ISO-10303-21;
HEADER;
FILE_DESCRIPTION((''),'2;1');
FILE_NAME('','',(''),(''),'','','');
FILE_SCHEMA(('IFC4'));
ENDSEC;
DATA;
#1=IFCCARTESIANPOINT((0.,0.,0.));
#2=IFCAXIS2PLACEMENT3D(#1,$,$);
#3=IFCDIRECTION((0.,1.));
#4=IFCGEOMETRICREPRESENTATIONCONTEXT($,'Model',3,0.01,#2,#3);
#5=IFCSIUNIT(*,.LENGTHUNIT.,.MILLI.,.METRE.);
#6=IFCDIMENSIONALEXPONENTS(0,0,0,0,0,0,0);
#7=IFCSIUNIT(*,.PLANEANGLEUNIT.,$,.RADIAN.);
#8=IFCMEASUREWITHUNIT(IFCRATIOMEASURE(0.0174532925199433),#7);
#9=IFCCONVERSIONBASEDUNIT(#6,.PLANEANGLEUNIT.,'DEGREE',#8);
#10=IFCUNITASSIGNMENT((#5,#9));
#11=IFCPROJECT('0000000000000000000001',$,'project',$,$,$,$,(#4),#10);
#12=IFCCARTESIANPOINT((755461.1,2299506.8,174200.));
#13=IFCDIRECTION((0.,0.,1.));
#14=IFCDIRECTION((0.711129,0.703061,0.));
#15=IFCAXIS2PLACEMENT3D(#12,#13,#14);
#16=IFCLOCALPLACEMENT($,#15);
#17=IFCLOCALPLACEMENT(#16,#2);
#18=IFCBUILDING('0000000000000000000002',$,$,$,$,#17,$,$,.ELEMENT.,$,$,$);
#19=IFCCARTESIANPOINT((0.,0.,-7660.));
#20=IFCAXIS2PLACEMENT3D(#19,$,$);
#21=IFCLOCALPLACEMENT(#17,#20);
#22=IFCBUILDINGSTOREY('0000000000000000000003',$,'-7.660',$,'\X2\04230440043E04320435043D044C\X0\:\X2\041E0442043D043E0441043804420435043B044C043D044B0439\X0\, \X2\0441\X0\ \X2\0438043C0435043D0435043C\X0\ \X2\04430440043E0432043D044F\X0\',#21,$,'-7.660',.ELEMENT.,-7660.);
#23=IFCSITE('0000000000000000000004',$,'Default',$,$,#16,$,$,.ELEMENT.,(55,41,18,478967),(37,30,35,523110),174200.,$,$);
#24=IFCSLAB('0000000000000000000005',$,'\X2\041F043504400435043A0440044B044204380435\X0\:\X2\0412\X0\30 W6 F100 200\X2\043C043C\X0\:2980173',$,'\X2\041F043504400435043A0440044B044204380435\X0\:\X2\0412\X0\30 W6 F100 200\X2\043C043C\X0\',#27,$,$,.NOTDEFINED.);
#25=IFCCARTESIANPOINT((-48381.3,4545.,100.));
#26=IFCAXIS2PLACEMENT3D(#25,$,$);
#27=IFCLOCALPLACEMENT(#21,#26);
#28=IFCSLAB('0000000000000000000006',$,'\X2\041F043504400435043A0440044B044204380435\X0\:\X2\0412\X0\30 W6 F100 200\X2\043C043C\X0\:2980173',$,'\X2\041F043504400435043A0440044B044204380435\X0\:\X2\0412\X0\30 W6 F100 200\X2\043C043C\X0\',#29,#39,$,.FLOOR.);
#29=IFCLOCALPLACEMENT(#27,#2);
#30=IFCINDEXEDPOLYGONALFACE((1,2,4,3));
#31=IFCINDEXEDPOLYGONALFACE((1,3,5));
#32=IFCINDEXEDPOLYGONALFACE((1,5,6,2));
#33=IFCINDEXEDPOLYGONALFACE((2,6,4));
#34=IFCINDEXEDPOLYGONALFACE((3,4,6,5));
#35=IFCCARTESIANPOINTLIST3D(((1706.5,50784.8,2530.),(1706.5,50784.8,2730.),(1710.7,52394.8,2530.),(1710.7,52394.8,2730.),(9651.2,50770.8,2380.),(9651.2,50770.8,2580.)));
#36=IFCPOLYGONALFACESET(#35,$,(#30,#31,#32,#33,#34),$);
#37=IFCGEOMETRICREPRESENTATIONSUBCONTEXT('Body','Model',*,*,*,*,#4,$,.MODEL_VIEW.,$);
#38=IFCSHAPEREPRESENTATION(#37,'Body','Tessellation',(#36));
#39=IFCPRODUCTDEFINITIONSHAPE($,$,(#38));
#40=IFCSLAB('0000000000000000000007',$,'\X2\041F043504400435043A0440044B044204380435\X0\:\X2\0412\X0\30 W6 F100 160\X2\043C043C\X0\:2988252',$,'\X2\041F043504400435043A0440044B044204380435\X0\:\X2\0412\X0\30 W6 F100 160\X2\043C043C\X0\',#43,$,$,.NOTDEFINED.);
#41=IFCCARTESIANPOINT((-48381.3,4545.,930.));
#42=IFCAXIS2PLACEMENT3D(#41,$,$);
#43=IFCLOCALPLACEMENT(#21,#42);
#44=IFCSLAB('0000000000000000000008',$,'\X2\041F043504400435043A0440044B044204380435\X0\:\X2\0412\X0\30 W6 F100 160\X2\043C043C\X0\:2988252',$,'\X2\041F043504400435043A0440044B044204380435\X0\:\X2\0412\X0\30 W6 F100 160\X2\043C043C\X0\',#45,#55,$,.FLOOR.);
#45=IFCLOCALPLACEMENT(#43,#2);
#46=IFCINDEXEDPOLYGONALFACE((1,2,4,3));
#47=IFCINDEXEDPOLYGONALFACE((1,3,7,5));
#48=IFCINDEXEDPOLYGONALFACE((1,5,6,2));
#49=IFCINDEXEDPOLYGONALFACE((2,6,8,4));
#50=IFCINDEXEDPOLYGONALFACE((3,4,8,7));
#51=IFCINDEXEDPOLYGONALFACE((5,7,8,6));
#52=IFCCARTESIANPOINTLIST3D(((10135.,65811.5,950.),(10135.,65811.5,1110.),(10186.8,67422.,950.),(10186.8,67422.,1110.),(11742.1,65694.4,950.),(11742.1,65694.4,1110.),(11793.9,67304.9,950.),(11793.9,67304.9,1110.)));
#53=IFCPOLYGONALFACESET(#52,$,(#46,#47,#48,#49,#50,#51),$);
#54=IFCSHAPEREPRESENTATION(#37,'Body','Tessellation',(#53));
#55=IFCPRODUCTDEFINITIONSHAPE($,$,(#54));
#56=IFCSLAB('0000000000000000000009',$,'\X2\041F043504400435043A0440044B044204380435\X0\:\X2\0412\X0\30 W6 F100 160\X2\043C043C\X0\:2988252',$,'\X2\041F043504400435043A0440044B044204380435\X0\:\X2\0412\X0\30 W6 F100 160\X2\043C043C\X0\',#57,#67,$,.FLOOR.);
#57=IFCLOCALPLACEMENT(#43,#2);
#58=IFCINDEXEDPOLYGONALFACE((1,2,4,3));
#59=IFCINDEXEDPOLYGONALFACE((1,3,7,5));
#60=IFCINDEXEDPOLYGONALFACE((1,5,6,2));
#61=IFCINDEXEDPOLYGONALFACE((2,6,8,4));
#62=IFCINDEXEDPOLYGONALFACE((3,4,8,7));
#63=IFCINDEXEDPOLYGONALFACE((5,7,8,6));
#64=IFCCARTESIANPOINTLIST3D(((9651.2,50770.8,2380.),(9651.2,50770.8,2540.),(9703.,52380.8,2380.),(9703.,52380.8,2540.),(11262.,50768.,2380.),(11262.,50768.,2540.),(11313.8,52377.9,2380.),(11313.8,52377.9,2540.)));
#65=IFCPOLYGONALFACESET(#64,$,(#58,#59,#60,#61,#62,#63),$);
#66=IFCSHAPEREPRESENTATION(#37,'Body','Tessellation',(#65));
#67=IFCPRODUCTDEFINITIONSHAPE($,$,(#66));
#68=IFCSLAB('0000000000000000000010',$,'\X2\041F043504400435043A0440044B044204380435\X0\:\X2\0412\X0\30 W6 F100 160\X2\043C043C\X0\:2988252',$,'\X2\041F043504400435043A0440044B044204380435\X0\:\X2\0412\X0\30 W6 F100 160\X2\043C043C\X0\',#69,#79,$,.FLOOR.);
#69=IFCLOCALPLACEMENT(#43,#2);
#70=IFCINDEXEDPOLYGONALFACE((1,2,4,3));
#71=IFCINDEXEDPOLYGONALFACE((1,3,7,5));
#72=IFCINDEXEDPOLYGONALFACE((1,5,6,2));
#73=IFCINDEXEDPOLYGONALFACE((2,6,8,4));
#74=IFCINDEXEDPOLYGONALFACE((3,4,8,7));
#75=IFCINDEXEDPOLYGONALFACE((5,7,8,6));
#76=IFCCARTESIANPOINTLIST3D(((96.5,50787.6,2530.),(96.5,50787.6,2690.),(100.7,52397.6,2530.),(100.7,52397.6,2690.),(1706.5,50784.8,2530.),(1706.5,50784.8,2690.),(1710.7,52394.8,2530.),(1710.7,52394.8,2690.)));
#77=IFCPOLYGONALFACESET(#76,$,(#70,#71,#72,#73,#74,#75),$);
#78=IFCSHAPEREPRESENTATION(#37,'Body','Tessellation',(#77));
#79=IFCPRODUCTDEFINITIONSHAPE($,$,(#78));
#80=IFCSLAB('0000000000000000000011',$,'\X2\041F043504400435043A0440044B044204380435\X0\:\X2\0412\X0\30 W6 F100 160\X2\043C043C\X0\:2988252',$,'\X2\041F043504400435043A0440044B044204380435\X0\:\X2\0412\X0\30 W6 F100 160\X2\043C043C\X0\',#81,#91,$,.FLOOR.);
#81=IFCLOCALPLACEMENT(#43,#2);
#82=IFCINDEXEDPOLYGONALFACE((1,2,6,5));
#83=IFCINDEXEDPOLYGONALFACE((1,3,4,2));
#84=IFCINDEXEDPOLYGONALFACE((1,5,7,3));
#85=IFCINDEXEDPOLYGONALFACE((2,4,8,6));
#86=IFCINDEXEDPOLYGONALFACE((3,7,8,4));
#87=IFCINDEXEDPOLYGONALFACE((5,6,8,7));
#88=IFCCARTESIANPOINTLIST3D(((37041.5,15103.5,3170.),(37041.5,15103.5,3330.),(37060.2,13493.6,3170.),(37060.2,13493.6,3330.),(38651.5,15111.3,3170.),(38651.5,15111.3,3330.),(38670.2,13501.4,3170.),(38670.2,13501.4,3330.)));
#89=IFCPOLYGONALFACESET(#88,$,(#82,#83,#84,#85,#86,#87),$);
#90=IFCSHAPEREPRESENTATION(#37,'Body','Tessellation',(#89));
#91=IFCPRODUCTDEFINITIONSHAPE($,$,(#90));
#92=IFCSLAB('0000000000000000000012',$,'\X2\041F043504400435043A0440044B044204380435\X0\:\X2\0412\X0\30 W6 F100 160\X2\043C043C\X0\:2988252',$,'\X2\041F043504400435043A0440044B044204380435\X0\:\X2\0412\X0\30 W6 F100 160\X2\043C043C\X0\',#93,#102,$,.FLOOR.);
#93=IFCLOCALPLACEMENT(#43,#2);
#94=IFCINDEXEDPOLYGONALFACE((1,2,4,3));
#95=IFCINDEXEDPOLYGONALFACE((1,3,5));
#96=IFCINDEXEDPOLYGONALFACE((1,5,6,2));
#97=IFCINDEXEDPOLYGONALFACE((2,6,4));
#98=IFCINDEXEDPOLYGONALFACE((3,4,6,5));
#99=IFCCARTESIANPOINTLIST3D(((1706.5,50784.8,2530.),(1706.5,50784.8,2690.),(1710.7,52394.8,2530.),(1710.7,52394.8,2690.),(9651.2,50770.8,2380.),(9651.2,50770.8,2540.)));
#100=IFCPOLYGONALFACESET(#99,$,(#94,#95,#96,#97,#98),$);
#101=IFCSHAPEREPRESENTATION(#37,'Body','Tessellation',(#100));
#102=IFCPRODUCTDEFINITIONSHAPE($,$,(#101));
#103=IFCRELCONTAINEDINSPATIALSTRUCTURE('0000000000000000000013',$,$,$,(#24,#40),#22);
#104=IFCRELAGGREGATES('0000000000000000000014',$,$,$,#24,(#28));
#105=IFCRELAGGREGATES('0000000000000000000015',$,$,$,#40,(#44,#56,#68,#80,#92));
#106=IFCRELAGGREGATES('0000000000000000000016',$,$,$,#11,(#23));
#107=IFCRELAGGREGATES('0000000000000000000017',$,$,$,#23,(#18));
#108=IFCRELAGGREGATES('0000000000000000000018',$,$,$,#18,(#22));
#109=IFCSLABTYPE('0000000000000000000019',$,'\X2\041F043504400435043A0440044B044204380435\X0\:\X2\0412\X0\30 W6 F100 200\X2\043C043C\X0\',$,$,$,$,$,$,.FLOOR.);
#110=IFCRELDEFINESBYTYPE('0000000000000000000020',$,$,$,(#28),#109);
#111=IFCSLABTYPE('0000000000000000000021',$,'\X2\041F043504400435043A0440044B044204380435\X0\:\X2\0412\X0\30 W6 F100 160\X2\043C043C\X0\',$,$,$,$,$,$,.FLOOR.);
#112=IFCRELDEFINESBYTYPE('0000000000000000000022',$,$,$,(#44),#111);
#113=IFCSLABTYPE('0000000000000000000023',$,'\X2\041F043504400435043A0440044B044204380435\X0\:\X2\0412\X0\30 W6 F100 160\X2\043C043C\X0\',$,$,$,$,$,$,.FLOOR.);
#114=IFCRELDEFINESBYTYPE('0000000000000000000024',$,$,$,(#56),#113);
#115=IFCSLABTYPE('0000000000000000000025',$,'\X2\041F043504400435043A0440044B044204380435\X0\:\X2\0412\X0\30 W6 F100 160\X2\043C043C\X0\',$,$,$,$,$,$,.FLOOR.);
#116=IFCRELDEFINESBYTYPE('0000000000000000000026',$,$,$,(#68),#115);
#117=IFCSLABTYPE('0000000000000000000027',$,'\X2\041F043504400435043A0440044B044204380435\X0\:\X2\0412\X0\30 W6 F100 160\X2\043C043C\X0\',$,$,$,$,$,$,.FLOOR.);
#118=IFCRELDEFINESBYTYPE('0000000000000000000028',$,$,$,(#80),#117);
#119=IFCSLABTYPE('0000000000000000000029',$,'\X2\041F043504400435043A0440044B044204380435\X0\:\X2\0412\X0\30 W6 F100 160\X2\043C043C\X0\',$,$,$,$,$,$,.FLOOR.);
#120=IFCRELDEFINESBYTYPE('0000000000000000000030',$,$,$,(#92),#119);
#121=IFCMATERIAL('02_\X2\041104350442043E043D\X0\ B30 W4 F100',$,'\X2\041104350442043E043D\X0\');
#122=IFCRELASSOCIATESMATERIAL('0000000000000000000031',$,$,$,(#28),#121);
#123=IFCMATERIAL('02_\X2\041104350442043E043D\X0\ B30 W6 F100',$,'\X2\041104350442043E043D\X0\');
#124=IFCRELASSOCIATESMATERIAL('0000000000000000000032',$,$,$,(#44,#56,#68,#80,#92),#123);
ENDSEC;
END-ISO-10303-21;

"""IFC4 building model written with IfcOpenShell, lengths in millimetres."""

from ifc_helpers import new_model, entity, si_unit, converted_unit, direction, frame, origin, place, context, subcontext, project, spatial, indexed_curve, outline, extrude, material, type_object, element, aggregate, save


model = new_model("IFC4")

# Units and contexts
model_context = context("Model", 3, precision=0.01, world=origin(), true_north=direction((0.0, 1.0)))
body_context = subcontext(model_context, "Body", "Model", "MODEL_VIEW")
ifc_project = project(units=[si_unit("LENGTHUNIT", "METRE", prefix="MILLI"), converted_unit("PLANEANGLEUNIT", "DEGREE", entity("IfcRatioMeasure", 0.0174532925199433), si_unit("PLANEANGLEUNIT", "RADIAN"), dimensions=[0, 0, 0, 0, 0, 0, 0])], contexts=[model_context])

# Site, building, storey
site_placement = place(None, frame((755461.1, 2299506.8, 174200.0), z_axis=(0.0, 0.0, 1.0), x_axis=(0.711129, 0.703061, 0.0)))
site = spatial("IfcSite", under=ifc_project, at=site_placement, Name="Default", CompositionType="ELEMENT", RefLatitude=(55, 41, 18, 478967), RefLongitude=(37, 30, 35, 523110), RefElevation=174200.0)
building_placement = place(site_placement, origin())
building = spatial("IfcBuilding", under=site, at=building_placement, CompositionType="ELEMENT")
storey_placement = place(building_placement, frame((0.0, 0.0, -7660.0)))
storey = spatial("IfcBuildingStorey", under=building, at=storey_placement, Name="-7.660", ObjectType="Уровень:Относительный, с именем уровня", LongName="-7.660", CompositionType="ELEMENT", Elevation=-7660.0)

# Slabs
slab_1_placement = place(storey_placement, frame((-48381.3, 4545.0, 100.0)))
slab_1 = element("IfcSlab", 1, at=slab_1_placement, inside=storey, Name="Перекрытие:В30 W6 F100 200мм:2980173", ObjectType="Перекрытие:В30 W6 F100 200мм", PredefinedType="NOTDEFINED")
ifc_material_1 = material(Name="02_Бетон B30 W4 F100", Category="Бетон")
slab_type_1 = type_object("IfcSlabType", Name="Перекрытие:В30 W6 F100 200мм", PredefinedType="FLOOR")
slab_2_placement = place(slab_1_placement, origin())
slab_2 = element("IfcSlab", 2, at=slab_2_placement, type_object=slab_type_1, material=ifc_material_1, Name="Перекрытие:В30 W6 F100 200мм:2980173", ObjectType="Перекрытие:В30 W6 F100 200мм", PredefinedType="FLOOR", context=body_context, shape_type="SweptSolid", body=[
    extrude(outline(indexed_curve([(-3974.5, -798.0), (3971.7, -812.0), (-3970.3, 812.0), (-3974.5, -798.0)], self_intersect=False)), frame((5680.3, 51582.8, 2655.0), z_axis=(0.018877, -0.000049, 0.999822), x_axis=(0.999822, 0.000001, -0.018877)), (0.018877, -0.000049, -0.999822), 200.0),
])
aggregate(slab_1, [slab_2])
slab_3_placement = place(storey_placement, frame((-48381.3, 4545.0, 930.0)))
slab_3 = element("IfcSlab", 3, at=slab_3_placement, inside=storey, Name="Перекрытие:В30 W6 F100 160мм:2988252", ObjectType="Перекрытие:В30 W6 F100 160мм", PredefinedType="NOTDEFINED")
ifc_material_2 = material(Name="02_Бетон B30 W6 F100", Category="Бетон")
slab_type_2 = type_object("IfcSlabType", Name="Перекрытие:В30 W6 F100 160мм", PredefinedType="FLOOR")
slab_4_placement = place(slab_3_placement, origin())
slab_4 = element("IfcSlab", 4, at=slab_4_placement, type_object=slab_type_2, material=ifc_material_2, Name="Перекрытие:В30 W6 F100 160мм:2988252", ObjectType="Перекрытие:В30 W6 F100 160мм", PredefinedType="FLOOR", context=body_context, shape_type="SweptSolid", body=[
    extrude(outline(indexed_curve([(-829.4, -746.7), (777.6, -863.8), (829.4, 746.7), (-777.6, 863.8), (-829.4, -746.7)], self_intersect=False)), frame((10964.4, 66558.2, 1110.0)), (0.0, 0.0, -1.0), 160.0),
])
slab_type_3 = type_object("IfcSlabType", Name="Перекрытие:В30 W6 F100 160мм", PredefinedType="FLOOR")
slab_5_placement = place(slab_3_placement, origin())
slab_5 = element("IfcSlab", 5, at=slab_5_placement, type_object=slab_type_3, material=ifc_material_2, Name="Перекрытие:В30 W6 F100 160мм:2988252", ObjectType="Перекрытие:В30 W6 F100 160мм", PredefinedType="FLOOR", context=body_context, shape_type="SweptSolid", body=[
    extrude(outline(indexed_curve([(-779.5, 806.4), (-831.3, -803.5), (779.5, -806.4), (831.3, 803.5), (-779.5, 806.4)], self_intersect=False)), frame((10482.5, 51574.4, 2540.0)), (0.0, 0.0, -1.0), 160.0),
])
slab_type_4 = type_object("IfcSlabType", Name="Перекрытие:В30 W6 F100 160мм", PredefinedType="FLOOR")
slab_6_placement = place(slab_3_placement, origin())
slab_6 = element("IfcSlab", 6, at=slab_6_placement, type_object=slab_type_4, material=ifc_material_2, Name="Перекрытие:В30 W6 F100 160мм:2988252", ObjectType="Перекрытие:В30 W6 F100 160мм", PredefinedType="FLOOR", context=body_context, shape_type="SweptSolid", body=[
    extrude(outline(indexed_curve([(-802.9, 806.4), (-807.1, -803.6), (802.9, -806.4), (807.1, 803.6), (-802.9, 806.4)], self_intersect=False)), frame((903.6, 51591.2, 2690.0)), (0.0, 0.0, -1.0), 160.0),
])
slab_type_5 = type_object("IfcSlabType", Name="Перекрытие:В30 W6 F100 160мм", PredefinedType="FLOOR")
slab_7_placement = place(slab_3_placement, origin())
slab_7 = element("IfcSlab", 7, at=slab_7_placement, type_object=slab_type_5, material=ifc_material_2, Name="Перекрытие:В30 W6 F100 160мм:2988252", ObjectType="Перекрытие:В30 W6 F100 160мм", PredefinedType="FLOOR", context=body_context, shape_type="SweptSolid", body=[
    extrude(outline(indexed_curve([(-795.7, -808.9), (814.4, -801.1), (795.7, 808.9), (-814.4, 801.1), (-795.7, -808.9)], self_intersect=False)), frame((37855.8, 14302.4, 3330.0)), (0.0, 0.0, -1.0), 160.0),
])
slab_type_6 = type_object("IfcSlabType", Name="Перекрытие:В30 W6 F100 160мм", PredefinedType="FLOOR")
slab_8_placement = place(slab_3_placement, origin())
slab_8 = element("IfcSlab", 8, at=slab_8_placement, type_object=slab_type_6, material=ifc_material_2, Name="Перекрытие:В30 W6 F100 160мм:2988252", ObjectType="Перекрытие:В30 W6 F100 160мм", PredefinedType="FLOOR", context=body_context, shape_type="SweptSolid", body=[
    extrude(outline(indexed_curve([(-3974.5, -798.0), (3971.7, -812.0), (-3970.3, 812.0), (-3974.5, -798.0)], self_intersect=False)), frame((5680.3, 51582.8, 2615.0), z_axis=(0.018877, -0.000049, 0.999822), x_axis=(0.999822, 0.000001, -0.018877)), (0.018877, -0.000049, -0.999822), 160.0),
])
aggregate(slab_3, [slab_4, slab_5, slab_6, slab_7, slab_8])

save(model, "model.ifc")
